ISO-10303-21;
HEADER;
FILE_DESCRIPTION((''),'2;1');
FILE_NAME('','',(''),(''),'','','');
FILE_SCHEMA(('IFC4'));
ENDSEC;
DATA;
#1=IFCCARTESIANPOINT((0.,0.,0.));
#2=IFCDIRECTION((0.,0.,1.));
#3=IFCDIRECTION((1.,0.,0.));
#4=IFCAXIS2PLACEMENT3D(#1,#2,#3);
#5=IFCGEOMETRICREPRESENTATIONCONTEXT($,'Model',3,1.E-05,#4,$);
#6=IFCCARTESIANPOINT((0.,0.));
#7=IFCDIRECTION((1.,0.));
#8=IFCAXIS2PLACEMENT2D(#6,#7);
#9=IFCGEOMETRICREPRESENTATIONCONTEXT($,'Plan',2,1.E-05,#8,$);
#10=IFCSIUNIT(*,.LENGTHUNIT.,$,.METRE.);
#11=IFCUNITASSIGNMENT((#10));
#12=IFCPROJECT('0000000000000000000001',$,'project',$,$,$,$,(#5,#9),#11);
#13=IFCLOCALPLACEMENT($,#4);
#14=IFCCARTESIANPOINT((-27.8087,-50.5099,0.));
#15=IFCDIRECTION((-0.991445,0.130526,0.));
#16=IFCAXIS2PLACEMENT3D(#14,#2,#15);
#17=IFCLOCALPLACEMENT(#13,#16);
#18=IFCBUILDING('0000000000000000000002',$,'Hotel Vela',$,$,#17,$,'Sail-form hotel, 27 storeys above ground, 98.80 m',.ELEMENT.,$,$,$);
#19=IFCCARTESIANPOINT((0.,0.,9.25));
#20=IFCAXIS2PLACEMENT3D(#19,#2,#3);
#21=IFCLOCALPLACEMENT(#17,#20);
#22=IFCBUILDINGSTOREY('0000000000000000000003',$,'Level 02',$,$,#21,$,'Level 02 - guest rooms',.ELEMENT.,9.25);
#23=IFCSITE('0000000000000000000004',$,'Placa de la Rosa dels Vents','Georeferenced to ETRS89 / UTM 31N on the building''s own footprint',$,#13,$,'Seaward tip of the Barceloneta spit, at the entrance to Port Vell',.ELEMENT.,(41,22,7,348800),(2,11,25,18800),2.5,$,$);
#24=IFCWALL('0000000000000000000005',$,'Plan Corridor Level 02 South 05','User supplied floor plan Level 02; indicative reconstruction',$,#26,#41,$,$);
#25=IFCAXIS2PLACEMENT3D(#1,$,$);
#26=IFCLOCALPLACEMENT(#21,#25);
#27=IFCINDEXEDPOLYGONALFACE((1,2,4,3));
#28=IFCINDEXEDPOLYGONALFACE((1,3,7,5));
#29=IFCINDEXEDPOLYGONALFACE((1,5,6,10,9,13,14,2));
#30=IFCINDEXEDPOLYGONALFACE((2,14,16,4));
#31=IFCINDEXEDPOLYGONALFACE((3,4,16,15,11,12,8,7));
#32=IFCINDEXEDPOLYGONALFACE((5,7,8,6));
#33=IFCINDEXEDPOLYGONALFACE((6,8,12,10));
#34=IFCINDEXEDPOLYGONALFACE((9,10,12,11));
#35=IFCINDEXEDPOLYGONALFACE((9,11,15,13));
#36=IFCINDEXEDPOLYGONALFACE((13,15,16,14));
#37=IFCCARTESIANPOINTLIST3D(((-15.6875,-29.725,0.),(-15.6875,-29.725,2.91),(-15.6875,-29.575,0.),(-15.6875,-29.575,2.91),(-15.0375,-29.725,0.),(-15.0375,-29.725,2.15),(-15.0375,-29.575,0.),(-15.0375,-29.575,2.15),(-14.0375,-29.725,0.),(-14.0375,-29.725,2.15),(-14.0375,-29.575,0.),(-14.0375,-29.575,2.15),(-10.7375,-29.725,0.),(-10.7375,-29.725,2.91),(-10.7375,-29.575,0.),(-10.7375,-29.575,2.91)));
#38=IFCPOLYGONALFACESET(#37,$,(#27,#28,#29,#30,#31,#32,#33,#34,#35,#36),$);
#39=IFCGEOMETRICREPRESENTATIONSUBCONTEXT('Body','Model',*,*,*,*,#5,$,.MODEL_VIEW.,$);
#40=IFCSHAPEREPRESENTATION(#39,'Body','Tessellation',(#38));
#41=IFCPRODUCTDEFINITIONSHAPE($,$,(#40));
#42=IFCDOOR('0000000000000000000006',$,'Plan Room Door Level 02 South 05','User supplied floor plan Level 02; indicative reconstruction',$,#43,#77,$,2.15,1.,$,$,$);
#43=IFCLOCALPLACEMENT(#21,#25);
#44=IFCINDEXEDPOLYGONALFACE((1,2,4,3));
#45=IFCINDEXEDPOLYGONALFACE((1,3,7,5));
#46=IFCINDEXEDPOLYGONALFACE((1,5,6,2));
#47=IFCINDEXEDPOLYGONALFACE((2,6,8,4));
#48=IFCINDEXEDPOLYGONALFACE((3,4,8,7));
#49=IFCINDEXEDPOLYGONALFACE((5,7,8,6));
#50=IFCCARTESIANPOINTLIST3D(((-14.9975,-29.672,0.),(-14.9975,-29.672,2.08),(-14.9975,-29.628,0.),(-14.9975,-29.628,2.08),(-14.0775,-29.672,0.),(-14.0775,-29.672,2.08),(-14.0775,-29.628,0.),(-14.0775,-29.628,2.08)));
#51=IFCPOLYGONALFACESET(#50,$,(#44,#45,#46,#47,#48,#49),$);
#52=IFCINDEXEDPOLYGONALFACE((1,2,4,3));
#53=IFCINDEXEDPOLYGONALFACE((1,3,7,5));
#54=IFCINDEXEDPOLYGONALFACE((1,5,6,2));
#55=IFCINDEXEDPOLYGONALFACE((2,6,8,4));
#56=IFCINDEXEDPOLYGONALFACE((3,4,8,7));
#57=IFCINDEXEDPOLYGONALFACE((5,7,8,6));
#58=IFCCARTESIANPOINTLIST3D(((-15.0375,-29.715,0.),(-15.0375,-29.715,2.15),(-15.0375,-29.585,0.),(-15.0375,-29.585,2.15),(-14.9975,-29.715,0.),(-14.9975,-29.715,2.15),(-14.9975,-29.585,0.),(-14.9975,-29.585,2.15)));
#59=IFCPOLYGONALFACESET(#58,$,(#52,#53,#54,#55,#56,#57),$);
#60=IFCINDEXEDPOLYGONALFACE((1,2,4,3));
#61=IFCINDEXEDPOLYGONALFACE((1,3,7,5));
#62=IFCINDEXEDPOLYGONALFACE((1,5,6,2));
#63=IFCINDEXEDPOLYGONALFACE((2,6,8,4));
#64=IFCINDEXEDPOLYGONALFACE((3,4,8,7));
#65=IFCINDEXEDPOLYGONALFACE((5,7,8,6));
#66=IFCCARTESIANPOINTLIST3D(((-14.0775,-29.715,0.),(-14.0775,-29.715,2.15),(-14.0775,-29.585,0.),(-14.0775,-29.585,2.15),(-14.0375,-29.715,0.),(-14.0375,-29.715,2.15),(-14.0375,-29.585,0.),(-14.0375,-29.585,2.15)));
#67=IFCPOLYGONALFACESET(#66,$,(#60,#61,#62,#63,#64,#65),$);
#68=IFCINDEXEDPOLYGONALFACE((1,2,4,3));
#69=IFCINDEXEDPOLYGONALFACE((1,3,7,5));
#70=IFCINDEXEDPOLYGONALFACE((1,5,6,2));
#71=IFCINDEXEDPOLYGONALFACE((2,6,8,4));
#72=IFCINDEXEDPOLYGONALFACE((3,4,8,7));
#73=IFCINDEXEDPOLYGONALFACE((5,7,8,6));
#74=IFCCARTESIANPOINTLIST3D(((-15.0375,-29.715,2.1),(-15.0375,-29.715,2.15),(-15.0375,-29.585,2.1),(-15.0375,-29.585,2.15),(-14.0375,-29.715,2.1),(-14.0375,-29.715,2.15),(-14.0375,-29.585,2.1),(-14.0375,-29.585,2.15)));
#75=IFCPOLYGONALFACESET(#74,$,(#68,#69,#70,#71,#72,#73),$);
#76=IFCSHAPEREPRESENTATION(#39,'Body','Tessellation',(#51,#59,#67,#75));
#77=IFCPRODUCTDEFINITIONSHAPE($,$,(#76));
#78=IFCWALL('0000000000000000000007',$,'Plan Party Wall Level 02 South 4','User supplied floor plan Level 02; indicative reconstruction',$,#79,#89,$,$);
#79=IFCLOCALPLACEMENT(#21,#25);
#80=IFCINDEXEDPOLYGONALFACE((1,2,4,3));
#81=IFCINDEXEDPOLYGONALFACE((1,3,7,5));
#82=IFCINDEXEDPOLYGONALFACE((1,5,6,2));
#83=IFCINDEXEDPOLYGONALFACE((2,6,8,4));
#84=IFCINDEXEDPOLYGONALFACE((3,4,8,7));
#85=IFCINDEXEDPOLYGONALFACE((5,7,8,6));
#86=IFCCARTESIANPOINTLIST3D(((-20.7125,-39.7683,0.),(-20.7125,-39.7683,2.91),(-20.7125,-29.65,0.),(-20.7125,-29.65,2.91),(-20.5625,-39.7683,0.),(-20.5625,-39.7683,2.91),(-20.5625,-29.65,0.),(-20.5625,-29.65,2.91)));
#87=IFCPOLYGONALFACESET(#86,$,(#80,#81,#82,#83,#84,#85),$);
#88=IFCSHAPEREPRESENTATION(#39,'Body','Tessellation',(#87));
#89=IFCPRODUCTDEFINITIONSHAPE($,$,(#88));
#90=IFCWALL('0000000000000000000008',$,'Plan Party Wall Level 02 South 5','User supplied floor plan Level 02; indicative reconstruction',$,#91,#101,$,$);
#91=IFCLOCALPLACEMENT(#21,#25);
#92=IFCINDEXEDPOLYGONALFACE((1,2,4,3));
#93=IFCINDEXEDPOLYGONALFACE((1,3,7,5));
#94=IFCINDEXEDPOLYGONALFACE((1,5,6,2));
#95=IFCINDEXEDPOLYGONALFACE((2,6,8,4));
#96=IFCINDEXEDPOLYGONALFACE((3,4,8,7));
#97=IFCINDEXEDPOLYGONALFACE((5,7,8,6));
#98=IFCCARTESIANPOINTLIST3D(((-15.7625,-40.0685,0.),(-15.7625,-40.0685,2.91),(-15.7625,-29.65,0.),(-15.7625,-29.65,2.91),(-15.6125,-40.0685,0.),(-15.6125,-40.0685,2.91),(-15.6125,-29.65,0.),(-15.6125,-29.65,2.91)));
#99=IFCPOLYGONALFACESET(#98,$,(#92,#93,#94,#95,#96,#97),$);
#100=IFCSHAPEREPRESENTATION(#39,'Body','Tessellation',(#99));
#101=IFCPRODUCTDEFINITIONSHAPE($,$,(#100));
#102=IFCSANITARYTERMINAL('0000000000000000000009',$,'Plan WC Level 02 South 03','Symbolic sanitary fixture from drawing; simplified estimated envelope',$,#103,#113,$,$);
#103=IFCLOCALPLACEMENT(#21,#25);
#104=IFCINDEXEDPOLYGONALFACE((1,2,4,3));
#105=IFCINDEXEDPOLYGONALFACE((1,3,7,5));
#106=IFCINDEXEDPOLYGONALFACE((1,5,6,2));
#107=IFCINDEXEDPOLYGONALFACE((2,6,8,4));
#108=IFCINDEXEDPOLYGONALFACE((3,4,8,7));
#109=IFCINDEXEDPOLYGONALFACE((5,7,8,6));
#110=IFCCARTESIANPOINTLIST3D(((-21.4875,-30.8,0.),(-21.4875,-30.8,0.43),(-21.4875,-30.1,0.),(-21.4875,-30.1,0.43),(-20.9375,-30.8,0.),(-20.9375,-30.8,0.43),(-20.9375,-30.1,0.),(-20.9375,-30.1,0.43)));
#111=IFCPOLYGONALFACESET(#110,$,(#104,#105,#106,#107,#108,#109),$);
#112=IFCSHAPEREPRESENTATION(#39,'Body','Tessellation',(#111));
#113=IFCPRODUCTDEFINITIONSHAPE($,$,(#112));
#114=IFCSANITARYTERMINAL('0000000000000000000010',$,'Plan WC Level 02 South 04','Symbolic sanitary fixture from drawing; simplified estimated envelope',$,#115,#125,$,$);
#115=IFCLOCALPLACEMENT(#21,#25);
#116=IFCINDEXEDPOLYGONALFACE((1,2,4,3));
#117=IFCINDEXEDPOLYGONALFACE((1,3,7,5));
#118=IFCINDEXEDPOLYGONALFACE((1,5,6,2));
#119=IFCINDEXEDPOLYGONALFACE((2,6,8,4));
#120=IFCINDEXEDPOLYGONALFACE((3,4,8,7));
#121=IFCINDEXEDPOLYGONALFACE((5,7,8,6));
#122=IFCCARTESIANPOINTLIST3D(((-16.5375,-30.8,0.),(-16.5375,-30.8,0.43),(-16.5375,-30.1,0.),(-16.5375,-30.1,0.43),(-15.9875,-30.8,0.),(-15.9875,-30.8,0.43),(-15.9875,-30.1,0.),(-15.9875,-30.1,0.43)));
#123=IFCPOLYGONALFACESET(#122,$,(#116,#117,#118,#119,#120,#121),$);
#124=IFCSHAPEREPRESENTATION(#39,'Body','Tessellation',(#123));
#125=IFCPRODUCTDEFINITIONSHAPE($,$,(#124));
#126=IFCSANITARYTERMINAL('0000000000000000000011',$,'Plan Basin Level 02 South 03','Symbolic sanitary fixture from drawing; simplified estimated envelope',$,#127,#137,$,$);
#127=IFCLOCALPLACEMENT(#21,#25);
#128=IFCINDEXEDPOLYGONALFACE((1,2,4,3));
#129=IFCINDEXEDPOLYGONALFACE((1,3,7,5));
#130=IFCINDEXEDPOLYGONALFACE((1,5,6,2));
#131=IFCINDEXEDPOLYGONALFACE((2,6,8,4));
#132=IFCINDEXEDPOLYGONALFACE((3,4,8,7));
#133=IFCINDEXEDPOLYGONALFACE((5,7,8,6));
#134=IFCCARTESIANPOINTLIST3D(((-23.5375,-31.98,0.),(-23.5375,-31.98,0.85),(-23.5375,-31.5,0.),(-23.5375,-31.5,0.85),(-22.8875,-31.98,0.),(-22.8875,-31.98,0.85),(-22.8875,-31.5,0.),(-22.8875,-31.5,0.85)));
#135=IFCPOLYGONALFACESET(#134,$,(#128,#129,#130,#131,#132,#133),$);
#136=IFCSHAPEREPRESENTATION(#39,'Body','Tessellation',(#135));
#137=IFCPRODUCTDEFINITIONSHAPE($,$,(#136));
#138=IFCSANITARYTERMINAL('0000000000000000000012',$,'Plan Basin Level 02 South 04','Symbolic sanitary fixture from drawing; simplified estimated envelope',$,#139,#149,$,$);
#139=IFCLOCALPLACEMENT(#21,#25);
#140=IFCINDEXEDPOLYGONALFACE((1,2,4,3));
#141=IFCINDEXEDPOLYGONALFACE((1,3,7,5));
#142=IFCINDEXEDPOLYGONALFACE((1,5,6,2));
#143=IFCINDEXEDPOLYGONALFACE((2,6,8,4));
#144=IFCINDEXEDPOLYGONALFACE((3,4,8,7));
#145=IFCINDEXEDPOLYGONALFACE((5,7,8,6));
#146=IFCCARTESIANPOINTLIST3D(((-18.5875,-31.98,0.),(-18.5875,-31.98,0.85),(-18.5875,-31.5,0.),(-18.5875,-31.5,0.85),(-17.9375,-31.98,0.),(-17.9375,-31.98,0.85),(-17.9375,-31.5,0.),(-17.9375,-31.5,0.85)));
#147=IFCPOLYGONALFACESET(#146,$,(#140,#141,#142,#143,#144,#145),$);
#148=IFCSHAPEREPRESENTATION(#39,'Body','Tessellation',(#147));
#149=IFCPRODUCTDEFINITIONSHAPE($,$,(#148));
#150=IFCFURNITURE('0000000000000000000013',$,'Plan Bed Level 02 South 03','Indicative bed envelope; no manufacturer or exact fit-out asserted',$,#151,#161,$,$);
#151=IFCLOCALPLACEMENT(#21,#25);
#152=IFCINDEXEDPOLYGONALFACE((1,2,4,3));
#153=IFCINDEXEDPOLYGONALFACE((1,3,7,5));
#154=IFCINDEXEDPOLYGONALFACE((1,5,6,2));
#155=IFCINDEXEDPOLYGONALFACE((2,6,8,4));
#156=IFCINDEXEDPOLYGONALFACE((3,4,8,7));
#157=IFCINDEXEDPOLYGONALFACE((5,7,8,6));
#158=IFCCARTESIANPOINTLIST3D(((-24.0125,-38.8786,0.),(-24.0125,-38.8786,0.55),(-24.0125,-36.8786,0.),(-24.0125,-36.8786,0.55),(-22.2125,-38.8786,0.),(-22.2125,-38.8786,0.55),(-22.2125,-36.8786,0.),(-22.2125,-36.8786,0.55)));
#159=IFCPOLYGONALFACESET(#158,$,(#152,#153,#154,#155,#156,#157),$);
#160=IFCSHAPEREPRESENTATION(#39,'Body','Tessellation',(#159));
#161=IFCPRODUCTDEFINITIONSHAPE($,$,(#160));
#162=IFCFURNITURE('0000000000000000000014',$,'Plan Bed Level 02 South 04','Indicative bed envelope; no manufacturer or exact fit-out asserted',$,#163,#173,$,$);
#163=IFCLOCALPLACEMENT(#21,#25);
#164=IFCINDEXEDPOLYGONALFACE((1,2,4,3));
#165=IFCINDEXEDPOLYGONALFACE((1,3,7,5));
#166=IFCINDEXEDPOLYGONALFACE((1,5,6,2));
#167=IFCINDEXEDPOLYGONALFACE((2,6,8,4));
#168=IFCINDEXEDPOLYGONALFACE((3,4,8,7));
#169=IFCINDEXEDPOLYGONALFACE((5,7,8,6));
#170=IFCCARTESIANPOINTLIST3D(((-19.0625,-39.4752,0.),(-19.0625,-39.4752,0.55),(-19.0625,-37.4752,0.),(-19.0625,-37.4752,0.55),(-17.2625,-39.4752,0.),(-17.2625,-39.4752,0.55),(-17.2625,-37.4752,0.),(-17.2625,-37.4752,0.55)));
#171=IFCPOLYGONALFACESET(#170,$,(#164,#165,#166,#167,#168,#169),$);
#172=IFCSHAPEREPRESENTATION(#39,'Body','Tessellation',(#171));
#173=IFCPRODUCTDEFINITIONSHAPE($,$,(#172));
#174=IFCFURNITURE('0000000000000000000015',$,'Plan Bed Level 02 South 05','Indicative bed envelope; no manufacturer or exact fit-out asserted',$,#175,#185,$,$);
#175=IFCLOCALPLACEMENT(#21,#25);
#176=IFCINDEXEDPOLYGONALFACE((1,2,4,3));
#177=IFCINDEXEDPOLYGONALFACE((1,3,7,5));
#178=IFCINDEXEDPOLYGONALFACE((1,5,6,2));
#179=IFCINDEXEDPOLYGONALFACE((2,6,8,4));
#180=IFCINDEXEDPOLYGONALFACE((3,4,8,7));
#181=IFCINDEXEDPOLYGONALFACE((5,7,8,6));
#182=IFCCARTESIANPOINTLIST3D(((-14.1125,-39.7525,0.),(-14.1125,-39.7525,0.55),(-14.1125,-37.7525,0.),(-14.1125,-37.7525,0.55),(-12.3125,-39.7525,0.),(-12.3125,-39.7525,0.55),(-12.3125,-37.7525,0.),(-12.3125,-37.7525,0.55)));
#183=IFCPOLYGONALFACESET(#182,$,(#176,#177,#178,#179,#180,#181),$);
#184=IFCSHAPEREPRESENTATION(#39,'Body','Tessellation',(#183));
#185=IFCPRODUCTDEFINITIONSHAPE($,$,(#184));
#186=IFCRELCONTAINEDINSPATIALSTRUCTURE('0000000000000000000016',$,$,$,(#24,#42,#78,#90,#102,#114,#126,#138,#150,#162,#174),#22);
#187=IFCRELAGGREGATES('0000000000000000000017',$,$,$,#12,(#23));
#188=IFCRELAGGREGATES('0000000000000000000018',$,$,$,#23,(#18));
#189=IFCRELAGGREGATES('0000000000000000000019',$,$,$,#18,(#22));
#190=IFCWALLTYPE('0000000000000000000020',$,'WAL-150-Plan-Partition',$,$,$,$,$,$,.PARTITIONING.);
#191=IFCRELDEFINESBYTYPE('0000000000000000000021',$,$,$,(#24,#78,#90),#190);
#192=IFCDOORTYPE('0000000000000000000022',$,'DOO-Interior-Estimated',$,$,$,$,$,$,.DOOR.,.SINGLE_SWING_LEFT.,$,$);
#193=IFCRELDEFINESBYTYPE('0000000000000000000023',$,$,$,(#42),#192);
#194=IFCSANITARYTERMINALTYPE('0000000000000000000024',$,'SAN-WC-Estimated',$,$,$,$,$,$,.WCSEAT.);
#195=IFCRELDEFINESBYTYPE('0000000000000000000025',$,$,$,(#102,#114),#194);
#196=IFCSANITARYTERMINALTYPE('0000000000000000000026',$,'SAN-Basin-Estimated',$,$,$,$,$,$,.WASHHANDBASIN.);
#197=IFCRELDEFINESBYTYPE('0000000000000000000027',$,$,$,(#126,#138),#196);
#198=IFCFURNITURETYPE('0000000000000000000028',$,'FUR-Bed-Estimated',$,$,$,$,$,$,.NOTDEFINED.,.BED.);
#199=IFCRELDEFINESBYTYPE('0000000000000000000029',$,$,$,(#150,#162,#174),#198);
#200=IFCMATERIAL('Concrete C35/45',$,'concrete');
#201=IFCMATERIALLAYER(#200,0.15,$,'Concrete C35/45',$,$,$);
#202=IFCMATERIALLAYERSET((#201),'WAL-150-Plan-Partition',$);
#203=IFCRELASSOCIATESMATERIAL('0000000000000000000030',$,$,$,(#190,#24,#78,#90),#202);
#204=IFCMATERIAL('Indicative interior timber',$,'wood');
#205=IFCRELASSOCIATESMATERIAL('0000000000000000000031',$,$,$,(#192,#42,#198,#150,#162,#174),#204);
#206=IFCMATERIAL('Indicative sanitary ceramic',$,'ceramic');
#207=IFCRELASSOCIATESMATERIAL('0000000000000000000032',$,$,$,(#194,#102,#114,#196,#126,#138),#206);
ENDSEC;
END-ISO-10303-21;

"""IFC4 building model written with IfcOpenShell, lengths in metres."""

from ifc_helpers import new_model, si_unit, frame, origin_with_axes, origin_2d_with_axis, place, context, subcontext, project, spatial, line, indexed_curve, outline, extrude, material, layer, layer_set, layer_usage, type_object, element, fill, save


model = new_model("IFC4")

# Units and contexts
model_context = context("Model", 3, precision=1e-05, world=origin_with_axes())
plan_context = context("Plan", 2, precision=1e-05, world=origin_2d_with_axis())
body_context = subcontext(model_context, "Body", "Model", "MODEL_VIEW")
ifc_project = project(units=[si_unit("LENGTHUNIT", "METRE")], contexts=[model_context, plan_context])

# Site, building, storey
site_placement = place(None, origin_with_axes())
site = spatial("IfcSite", under=ifc_project, at=site_placement, Name="Placa de la Rosa dels Vents", Description="Georeferenced to ETRS89 / UTM 31N on the building's own footprint", LongName="Seaward tip of the Barceloneta spit, at the entrance to Port Vell", CompositionType="ELEMENT", RefLatitude=(41, 22, 7, 348800), RefLongitude=(2, 11, 25, 18800), RefElevation=2.5)
building_placement = place(site_placement, frame((-27.8087, -50.5099, 0.0), z_axis=(0.0, 0.0, 1.0), x_axis=(-0.991445, 0.130526, 0.0)))
building = spatial("IfcBuilding", under=site, at=building_placement, Name="Hotel Vela", LongName="Sail-form hotel, 27 storeys above ground, 98.80 m", CompositionType="ELEMENT")
storey_placement = place(building_placement, frame((0.0, 0.0, 9.25), z_axis=(0.0, 0.0, 1.0), x_axis=(1.0, 0.0, 0.0)))
storey = spatial("IfcBuildingStorey", under=building, at=storey_placement, Name="Level 02", LongName="Level 02 - guest rooms", CompositionType="ELEMENT", Elevation=9.25)

# Shared definitions
ifc_material_1 = material(Name="Concrete C35/45", Category="concrete")
ifc_layer = layer(ifc_material_1, 0.15, Name="Concrete C35/45")
ifc_layer_set = layer_set([ifc_layer], Name="WAL-150-Plan-Partition")
wall_type = type_object("IfcWallType", Name="WAL-150-Plan-Partition", PredefinedType="PARTITIONING", material=ifc_layer_set)
ifc_material_2 = material(Name="Indicative interior timber", Category="wood")
door_type = type_object("IfcDoorType", Name="DOO-Interior-Estimated", OperationType="SINGLE_SWING_LEFT", PredefinedType="DOOR", material=ifc_material_2)

# Wall, opening, door
ifc_layer_usage_1 = layer_usage(ifc_layer_set, "AXIS2", "POSITIVE", 0.0)
wall_1_placement = place(storey_placement, frame((-15.6875, -29.725, 0.0), z_axis=(0.0, 0.0, 1.0), x_axis=(1.0, 0.0, 0.0)))
wall_1 = element("IfcWall", 1, at=wall_1_placement, inside=storey, type_object=wall_type, material=ifc_layer_usage_1, Name="Plan Corridor Level 02 South 05", Description="User supplied floor plan Level 02; indicative reconstruction", context=body_context, shape_type="SweptSolid", body=[
    extrude(outline(indexed_curve([(0.0, 0.0), (4.95, 0.0), (4.95, 0.15), (0.0, 0.15)], segments=[line(1, 2, 3, 4, 1)])), origin_with_axes(), (0.0, 0.0, 1.0), 2.91),
])
opening_1_placement = place(wall_1_placement, frame((0.65, -0.085, 0.0), z_axis=(0.0, 0.0, 1.0), x_axis=(1.0, 0.0, 0.0)))
opening_1 = element("IfcOpeningElement", 2, at=opening_1_placement, cuts=wall_1, PredefinedType="OPENING", context=body_context, shape_type="SweptSolid", body=[
    extrude(outline(indexed_curve([(0.0, 0.0), (1.0, 0.0), (1.0, 0.32), (0.0, 0.32)], segments=[line(1, 2, 3, 4, 1)])), origin_with_axes(), (0.0, 0.0, 1.0), 2.15),
])
door_1_placement = place(storey_placement, frame((0.0, 0.0, -9.25), z_axis=(0.0, 0.0, 1.0), x_axis=(1.0, 0.0, 0.0)))
door_1 = element("IfcDoor", 3, at=door_1_placement, inside=storey, type_object=door_type, material=ifc_material_2, Name="Plan Room Door Level 02 South 05", Description="User supplied floor plan Level 02; indicative reconstruction", OverallHeight=2.15, OverallWidth=1.0, context=body_context, shape_type="SweptSolid", body=[
    extrude(outline(indexed_curve([(0.0, 0.0), (0.92, 0.0), (0.92, 0.044), (0.0, 0.044)], segments=[line(1, 2, 3, 4, 1)])), frame((-14.9975, -29.672, 9.25), z_axis=(0.0, 0.0, 1.0), x_axis=(1.0, 0.0, 0.0)), (0.0, 0.0, 1.0), 2.08),
    extrude(outline(indexed_curve([(0.0, 0.0), (0.04, 0.0), (0.04, 0.13), (0.0, 0.13)], segments=[line(1, 2, 3, 4, 1)])), frame((-15.0375, -29.715, 9.25), z_axis=(0.0, 0.0, 1.0), x_axis=(1.0, 0.0, 0.0)), (0.0, 0.0, 1.0), 2.15),
    extrude(outline(indexed_curve([(0.0, 0.0), (0.04, 0.0), (0.04, 0.13), (0.0, 0.13)], segments=[line(1, 2, 3, 4, 1)])), frame((-14.0775, -29.715, 9.25), z_axis=(0.0, 0.0, 1.0), x_axis=(1.0, 0.0, 0.0)), (0.0, 0.0, 1.0), 2.15),
    extrude(outline(indexed_curve([(0.0, 0.0), (1.0, 0.0), (1.0, 0.13), (0.0, 0.13)], segments=[line(1, 2, 3, 4, 1)])), frame((-15.0375, -29.715, 11.35), z_axis=(0.0, 0.0, 1.0), x_axis=(1.0, 0.0, 0.0)), (0.0, 0.0, 1.0), 0.05),
])
fill(opening_1, door_1)

# Walls
ifc_layer_usage_2 = layer_usage(ifc_layer_set, "AXIS2", "POSITIVE", 0.0)
wall_2_placement = place(storey_placement, frame((-20.7125, -39.7683, 0.0), z_axis=(0.0, 0.0, 1.0), x_axis=(1.0, 0.0, 0.0)))
element("IfcWall", 4, at=wall_2_placement, inside=storey, type_object=wall_type, material=ifc_layer_usage_2, Name="Plan Party Wall Level 02 South 4", Description="User supplied floor plan Level 02; indicative reconstruction", context=body_context, shape_type="SweptSolid", body=[
    extrude(outline(indexed_curve([(0.0, 0.0), (0.15, 0.0), (0.15, 10.1183), (0.0, 10.1183)], segments=[line(1, 2, 3, 4, 1)])), origin_with_axes(), (0.0, 0.0, 1.0), 2.91),
])
ifc_layer_usage_3 = layer_usage(ifc_layer_set, "AXIS2", "POSITIVE", 0.0)
wall_3_placement = place(storey_placement, frame((-15.7625, -40.0685, 0.0), z_axis=(0.0, 0.0, 1.0), x_axis=(1.0, 0.0, 0.0)))
element("IfcWall", 5, at=wall_3_placement, inside=storey, type_object=wall_type, material=ifc_layer_usage_3, Name="Plan Party Wall Level 02 South 5", Description="User supplied floor plan Level 02; indicative reconstruction", context=body_context, shape_type="SweptSolid", body=[
    extrude(outline(indexed_curve([(0.0, 0.0), (0.15, 0.0), (0.15, 10.4185), (0.0, 10.4185)], segments=[line(1, 2, 3, 4, 1)])), origin_with_axes(), (0.0, 0.0, 1.0), 2.91),
])

# Sanitary terminals
ifc_material_3 = material(Name="Indicative sanitary ceramic", Category="ceramic")
sanitary_terminal_type_1 = type_object("IfcSanitaryTerminalType", Name="SAN-WC-Estimated", PredefinedType="WCSEAT", material=ifc_material_3)
for number, where, z_axis, x_axis, name in (
    (6, (-21.4875, -30.8, 0.0), (0.0, 0.0, 1.0), (1.0, 0.0, 0.0), "Plan WC Level 02 South 03"),
    (7, (-16.5375, -30.8, 0.0), (0.0, 0.0, 1.0), (1.0, 0.0, 0.0), "Plan WC Level 02 South 04"),
):
    element("IfcSanitaryTerminal", number, at=place(storey_placement, frame(where, z_axis=z_axis, x_axis=x_axis)), inside=storey, type_object=sanitary_terminal_type_1, material=ifc_material_3, Name=name, Description="Symbolic sanitary fixture from drawing; simplified estimated envelope", context=body_context, shape_type="SweptSolid", body=[
        extrude(outline(indexed_curve([(0.0, 0.0), (0.55, 0.0), (0.55, 0.7), (0.0, 0.7)], segments=[line(1, 2, 3, 4, 1)])), origin_with_axes(), (0.0, 0.0, 1.0), 0.43),
    ])
sanitary_terminal_type_2 = type_object("IfcSanitaryTerminalType", Name="SAN-Basin-Estimated", PredefinedType="WASHHANDBASIN", material=ifc_material_3)
for number, where, z_axis, x_axis, name in (
    (8, (-23.5375, -31.98, 0.0), (0.0, 0.0, 1.0), (1.0, 0.0, 0.0), "Plan Basin Level 02 South 03"),
    (9, (-18.5875, -31.98, 0.0), (0.0, 0.0, 1.0), (1.0, 0.0, 0.0), "Plan Basin Level 02 South 04"),
):
    element("IfcSanitaryTerminal", number, at=place(storey_placement, frame(where, z_axis=z_axis, x_axis=x_axis)), inside=storey, type_object=sanitary_terminal_type_2, material=ifc_material_3, Name=name, Description="Symbolic sanitary fixture from drawing; simplified estimated envelope", context=body_context, shape_type="SweptSolid", body=[
        extrude(outline(indexed_curve([(0.0, 0.0), (0.65, 0.0), (0.65, 0.48), (0.0, 0.48)], segments=[line(1, 2, 3, 4, 1)])), origin_with_axes(), (0.0, 0.0, 1.0), 0.85),
    ])

# Furniture
furniture_type = type_object("IfcFurnitureType", Name="FUR-Bed-Estimated", AssemblyPlace="NOTDEFINED", PredefinedType="BED", material=ifc_material_2)
for number, where, z_axis, x_axis, name in (
    (10, (-24.0125, -38.8786, 0.0), (0.0, 0.0, 1.0), (1.0, 0.0, 0.0), "Plan Bed Level 02 South 03"),
    (11, (-19.0625, -39.4752, 0.0), (0.0, 0.0, 1.0), (1.0, 0.0, 0.0), "Plan Bed Level 02 South 04"),
    (12, (-14.1125, -39.7525, 0.0), (0.0, 0.0, 1.0), (1.0, 0.0, 0.0), "Plan Bed Level 02 South 05"),
):
    element("IfcFurniture", number, at=place(storey_placement, frame(where, z_axis=z_axis, x_axis=x_axis)), inside=storey, type_object=furniture_type, material=ifc_material_2, Name=name, Description="Indicative bed envelope; no manufacturer or exact fit-out asserted", context=body_context, shape_type="SweptSolid", body=[
        extrude(outline(indexed_curve([(0.0, 0.0), (1.8, 0.0), (1.8, 2.0), (0.0, 2.0)], segments=[line(1, 2, 3, 4, 1)])), origin_with_axes(), (0.0, 0.0, 1.0), 0.55),
    ])

save(model, "model.ifc")
